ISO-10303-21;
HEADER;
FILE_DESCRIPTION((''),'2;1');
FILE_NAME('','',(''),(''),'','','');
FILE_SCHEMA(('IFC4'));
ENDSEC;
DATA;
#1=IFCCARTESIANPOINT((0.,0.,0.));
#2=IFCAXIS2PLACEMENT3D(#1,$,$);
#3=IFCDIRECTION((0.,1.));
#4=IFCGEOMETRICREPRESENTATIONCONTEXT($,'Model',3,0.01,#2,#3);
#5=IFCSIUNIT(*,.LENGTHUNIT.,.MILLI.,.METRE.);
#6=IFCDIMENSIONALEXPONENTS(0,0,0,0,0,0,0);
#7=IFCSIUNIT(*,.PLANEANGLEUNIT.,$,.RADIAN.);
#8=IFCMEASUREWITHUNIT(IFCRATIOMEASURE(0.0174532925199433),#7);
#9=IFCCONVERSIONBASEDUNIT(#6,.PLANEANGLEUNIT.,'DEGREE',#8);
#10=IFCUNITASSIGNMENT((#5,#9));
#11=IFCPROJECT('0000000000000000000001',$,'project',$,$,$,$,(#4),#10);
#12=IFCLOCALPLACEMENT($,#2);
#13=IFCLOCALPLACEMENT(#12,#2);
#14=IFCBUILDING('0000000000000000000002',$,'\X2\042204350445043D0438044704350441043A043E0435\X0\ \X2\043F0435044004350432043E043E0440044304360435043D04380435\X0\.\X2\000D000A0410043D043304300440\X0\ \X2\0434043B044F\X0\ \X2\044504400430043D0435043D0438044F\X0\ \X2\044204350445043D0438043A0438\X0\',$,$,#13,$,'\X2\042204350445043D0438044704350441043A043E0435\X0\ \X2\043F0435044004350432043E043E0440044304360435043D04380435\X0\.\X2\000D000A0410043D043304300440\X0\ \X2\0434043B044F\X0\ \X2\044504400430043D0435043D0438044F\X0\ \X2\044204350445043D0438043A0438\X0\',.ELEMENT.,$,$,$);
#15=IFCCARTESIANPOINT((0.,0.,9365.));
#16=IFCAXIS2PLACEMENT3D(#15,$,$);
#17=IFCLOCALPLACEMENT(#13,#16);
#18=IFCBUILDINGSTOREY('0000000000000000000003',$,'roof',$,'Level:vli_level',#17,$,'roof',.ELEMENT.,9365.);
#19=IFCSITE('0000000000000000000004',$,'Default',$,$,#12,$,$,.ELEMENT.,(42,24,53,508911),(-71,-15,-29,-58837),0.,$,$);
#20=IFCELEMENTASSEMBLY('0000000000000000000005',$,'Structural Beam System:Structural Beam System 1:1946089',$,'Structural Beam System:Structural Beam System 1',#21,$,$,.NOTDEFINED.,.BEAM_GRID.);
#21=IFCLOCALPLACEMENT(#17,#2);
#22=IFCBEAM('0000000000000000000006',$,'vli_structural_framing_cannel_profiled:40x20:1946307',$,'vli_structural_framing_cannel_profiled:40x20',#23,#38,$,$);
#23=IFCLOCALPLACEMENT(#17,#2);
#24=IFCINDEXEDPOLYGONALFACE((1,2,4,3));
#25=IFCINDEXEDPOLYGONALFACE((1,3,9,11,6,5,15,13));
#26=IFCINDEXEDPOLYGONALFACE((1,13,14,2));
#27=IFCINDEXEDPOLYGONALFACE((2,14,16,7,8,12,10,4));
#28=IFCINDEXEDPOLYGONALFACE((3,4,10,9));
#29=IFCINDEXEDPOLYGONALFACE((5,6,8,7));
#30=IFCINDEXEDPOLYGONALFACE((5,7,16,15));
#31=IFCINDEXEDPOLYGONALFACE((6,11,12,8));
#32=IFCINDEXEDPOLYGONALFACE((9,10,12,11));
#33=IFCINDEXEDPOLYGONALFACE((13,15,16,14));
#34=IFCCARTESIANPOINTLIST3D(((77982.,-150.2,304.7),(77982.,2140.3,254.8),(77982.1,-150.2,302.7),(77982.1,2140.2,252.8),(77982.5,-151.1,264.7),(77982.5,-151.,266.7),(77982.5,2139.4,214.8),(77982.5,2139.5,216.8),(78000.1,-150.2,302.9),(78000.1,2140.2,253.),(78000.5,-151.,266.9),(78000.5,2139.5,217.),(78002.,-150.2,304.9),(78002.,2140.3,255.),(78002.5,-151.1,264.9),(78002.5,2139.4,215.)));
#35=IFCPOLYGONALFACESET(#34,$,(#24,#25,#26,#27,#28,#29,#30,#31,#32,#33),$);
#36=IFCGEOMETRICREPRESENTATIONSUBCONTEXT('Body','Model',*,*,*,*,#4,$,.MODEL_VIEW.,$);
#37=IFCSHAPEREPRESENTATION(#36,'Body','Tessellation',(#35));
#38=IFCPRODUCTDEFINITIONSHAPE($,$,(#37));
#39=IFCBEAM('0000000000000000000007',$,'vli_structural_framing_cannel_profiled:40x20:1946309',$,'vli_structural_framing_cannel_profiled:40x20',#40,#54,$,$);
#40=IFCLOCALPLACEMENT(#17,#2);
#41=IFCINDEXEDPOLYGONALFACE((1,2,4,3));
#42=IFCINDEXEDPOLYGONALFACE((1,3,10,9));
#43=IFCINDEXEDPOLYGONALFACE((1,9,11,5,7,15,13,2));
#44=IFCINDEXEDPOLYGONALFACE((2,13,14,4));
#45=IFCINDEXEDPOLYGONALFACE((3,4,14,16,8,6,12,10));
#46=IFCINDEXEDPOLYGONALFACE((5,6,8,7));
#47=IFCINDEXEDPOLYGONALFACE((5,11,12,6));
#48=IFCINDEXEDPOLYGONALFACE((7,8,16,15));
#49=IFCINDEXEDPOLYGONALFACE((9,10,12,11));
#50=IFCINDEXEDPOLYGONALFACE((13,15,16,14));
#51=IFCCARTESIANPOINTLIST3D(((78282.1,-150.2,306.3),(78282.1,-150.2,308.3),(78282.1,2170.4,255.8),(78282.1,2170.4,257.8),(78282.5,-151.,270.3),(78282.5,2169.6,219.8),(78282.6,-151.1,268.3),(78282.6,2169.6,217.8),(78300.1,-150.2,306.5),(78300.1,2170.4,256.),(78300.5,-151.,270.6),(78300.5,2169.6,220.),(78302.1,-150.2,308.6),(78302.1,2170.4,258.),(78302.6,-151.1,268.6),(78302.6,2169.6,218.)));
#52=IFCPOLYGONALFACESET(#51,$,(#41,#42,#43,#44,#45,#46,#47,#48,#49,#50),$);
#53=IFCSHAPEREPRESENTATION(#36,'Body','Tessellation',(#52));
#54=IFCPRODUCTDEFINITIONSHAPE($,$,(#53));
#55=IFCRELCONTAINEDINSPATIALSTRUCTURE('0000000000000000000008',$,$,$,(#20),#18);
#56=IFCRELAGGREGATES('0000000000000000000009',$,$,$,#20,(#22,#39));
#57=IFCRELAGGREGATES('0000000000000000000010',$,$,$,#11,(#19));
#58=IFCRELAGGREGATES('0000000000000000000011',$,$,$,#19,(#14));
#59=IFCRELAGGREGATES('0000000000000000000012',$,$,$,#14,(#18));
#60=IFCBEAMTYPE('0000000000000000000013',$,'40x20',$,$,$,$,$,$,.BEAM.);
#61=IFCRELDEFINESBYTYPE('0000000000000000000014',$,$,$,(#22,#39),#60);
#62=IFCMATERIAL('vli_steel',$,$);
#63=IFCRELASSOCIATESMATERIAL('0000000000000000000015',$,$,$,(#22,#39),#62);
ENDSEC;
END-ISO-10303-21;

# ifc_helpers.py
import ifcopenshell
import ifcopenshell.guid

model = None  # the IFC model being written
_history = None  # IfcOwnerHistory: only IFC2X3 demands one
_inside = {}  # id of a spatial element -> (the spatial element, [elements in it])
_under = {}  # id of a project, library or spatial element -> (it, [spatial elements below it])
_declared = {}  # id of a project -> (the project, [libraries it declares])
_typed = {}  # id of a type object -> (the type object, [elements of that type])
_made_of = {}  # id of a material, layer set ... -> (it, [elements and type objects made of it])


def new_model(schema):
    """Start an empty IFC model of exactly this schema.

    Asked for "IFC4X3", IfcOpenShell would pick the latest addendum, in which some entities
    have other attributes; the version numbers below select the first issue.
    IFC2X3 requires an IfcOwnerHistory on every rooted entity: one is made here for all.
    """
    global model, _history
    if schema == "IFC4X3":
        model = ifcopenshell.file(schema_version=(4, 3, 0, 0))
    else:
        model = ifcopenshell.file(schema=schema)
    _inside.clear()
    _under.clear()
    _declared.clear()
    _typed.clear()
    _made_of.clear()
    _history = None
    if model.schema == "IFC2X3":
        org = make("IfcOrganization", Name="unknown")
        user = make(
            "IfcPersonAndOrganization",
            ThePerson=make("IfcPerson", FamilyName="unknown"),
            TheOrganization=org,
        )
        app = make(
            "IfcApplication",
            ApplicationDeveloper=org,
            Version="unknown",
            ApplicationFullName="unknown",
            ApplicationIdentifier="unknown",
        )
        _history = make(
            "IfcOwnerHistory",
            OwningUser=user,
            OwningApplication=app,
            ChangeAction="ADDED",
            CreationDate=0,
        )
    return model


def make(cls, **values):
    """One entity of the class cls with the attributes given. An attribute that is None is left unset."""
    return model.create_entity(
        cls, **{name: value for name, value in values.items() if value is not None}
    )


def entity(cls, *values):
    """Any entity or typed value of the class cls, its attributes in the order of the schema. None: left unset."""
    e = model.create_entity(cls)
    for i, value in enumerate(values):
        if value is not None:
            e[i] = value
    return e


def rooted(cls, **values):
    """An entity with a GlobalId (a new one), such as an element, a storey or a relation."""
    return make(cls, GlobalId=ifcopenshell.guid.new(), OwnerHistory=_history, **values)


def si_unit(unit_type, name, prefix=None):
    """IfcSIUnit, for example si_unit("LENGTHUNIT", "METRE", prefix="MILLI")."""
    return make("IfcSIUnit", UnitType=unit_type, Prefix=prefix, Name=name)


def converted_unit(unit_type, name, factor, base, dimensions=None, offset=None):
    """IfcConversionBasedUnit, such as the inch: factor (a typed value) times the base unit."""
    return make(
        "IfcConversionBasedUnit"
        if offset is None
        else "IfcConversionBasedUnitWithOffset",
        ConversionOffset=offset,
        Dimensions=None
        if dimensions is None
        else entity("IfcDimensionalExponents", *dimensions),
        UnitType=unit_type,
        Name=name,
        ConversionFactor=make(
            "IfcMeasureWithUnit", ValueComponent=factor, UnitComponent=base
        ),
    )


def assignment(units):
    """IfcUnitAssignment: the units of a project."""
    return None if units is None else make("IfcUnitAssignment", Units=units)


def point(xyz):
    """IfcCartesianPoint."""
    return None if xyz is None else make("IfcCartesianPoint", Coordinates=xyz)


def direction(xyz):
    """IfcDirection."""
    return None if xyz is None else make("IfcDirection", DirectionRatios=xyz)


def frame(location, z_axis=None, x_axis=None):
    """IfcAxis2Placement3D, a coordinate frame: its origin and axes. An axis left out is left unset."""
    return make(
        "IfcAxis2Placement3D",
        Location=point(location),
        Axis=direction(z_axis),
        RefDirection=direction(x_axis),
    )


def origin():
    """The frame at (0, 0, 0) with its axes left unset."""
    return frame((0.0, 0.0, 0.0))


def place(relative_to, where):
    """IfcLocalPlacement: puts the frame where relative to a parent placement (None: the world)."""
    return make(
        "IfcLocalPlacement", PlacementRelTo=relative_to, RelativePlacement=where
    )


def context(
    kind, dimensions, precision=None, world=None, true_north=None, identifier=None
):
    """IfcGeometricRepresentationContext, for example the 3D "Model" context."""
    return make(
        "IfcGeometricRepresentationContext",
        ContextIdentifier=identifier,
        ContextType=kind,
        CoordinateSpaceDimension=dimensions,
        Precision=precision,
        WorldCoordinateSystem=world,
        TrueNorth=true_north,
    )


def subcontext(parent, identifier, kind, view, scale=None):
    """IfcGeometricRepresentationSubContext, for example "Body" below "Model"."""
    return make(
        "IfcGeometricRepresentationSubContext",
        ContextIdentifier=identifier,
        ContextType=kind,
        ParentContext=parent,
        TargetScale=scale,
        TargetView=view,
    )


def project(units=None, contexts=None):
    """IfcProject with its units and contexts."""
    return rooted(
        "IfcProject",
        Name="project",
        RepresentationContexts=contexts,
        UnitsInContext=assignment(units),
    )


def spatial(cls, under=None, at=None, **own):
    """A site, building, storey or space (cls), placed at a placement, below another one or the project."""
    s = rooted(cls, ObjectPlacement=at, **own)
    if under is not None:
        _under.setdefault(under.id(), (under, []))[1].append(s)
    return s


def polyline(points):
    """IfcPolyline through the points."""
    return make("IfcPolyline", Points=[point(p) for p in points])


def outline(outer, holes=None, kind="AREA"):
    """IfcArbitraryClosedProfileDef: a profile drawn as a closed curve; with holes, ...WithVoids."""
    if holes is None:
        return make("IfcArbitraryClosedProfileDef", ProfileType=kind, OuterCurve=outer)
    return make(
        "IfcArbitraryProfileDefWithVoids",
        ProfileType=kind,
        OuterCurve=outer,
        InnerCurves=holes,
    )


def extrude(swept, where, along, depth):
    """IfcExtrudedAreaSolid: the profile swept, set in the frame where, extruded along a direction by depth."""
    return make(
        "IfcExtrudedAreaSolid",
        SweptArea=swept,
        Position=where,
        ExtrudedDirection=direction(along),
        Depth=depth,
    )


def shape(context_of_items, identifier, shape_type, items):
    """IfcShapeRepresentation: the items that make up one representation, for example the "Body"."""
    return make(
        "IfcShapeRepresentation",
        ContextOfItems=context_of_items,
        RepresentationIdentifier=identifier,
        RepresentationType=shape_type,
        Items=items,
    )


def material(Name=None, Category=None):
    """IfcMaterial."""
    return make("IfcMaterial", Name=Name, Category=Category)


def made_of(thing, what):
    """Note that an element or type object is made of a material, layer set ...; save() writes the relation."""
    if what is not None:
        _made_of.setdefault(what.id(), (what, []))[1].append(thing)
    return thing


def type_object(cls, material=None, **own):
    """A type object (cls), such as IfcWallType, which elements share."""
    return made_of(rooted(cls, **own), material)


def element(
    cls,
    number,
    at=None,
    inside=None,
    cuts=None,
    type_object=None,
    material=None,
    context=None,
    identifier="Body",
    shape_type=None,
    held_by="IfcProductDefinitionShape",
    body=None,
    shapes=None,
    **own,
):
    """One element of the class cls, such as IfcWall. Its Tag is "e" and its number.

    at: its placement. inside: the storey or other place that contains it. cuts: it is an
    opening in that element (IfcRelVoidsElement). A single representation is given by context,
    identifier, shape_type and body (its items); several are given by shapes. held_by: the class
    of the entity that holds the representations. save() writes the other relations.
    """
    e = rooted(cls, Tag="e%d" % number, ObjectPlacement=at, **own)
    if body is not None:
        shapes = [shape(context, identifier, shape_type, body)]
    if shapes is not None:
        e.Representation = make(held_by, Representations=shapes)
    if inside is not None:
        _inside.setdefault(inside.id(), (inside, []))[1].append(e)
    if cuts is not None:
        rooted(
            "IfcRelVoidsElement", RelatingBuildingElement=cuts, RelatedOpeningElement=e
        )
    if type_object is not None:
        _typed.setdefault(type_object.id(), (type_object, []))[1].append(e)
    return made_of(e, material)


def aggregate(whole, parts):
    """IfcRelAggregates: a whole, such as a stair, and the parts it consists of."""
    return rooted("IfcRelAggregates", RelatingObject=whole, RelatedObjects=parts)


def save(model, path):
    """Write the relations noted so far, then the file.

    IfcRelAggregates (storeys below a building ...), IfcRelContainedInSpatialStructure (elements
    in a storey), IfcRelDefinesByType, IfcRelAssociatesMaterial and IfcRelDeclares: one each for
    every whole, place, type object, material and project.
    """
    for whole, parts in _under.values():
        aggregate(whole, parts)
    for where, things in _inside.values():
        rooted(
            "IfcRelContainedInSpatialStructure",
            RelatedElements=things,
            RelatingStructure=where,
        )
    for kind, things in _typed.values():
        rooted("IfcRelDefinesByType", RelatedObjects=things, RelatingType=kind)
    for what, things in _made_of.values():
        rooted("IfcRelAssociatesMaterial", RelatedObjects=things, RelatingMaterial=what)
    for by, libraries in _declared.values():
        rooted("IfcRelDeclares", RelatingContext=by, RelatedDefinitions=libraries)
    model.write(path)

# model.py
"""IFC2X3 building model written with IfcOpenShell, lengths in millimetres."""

from ifc_helpers import new_model, entity, si_unit, converted_unit, direction, frame, origin, place, context, subcontext, project, spatial, polyline, outline, extrude, material, type_object, element, aggregate, save


model = new_model("IFC2X3")

# Units and contexts
model_context = context("Model", 3, precision=0.01, world=origin(), true_north=direction((0.0, 1.0)))
body_context = subcontext(model_context, "Body", "Model", "MODEL_VIEW")
ifc_project = project(units=[si_unit("LENGTHUNIT", "METRE", prefix="MILLI"), converted_unit("PLANEANGLEUNIT", "DEGREE", entity("IfcRatioMeasure", 0.0174532925199433), si_unit("PLANEANGLEUNIT", "RADIAN"), dimensions=[0, 0, 0, 0, 0, 0, 0])], contexts=[model_context])

# Site, building, storey
site_placement = place(None, origin())
site = spatial("IfcSite", under=ifc_project, at=site_placement, Name="Default", CompositionType="ELEMENT", RefLatitude=(42, 24, 53, 508911), RefLongitude=(-71, -15, -29, -58837), RefElevation=0.0)
building_placement = place(site_placement, origin())
building = spatial("IfcBuilding", under=site, at=building_placement, Name="Техническое перевооружение.\r\nАнгар для хранения техники", LongName="Техническое перевооружение.\r\nАнгар для хранения техники", CompositionType="ELEMENT")
storey_placement = place(building_placement, frame((0.0, 0.0, 9365.0)))
storey = spatial("IfcBuildingStorey", under=building, at=storey_placement, Name="roof", ObjectType="Level:vli_level", LongName="roof", CompositionType="ELEMENT", Elevation=9365.0)

# Element assembly, beams
ifc_material = material(Name="vli_steel")
beam_type = type_object("IfcBeamType", Name="40x20", PredefinedType="BEAM")
assembly_1_placement = place(storey_placement, origin())
assembly_1 = element("IfcElementAssembly", 1, at=assembly_1_placement, inside=storey, Name="Structural Beam System:Structural Beam System 1:1946089", ObjectType="Structural Beam System:Structural Beam System 1", AssemblyPlace="NOTDEFINED", PredefinedType="BEAM_GRID")
beam_1_placement = place(assembly_1_placement, frame((78001.4, 2140.3, 255.0), z_axis=(0.0, 0.021775, 0.999763), x_axis=(0.0, -0.999763, 0.021775)))
beam_1 = element("IfcBeam", 2, at=beam_1_placement, type_object=beam_type, material=ifc_material, Name="vli_structural_framing_cannel_profiled:40x20:1946307", ObjectType="vli_structural_framing_cannel_profiled:40x20", context=body_context, shape_type="SweptSolid", body=[
    extrude(outline(polyline([(-10.5, -20.0), (9.5, -20.0), (9.5, -18.0), (-8.5, -18.0), (-8.5, 18.0), (9.5, 18.0), (9.5, 20.0), (-10.5, 20.0), (-10.5, -20.0)])), frame((0.0, -9.7, -20.1), z_axis=(1.0, 0.0, 0.0), x_axis=(0.0, -0.999925, -0.01227)), (0.0, 0.0, 1.0), 2291.0),
])
beam_2_placement = place(assembly_1_placement, frame((78301.5, 2170.4, 258.0), z_axis=(0.0, 0.021775, 0.999763), x_axis=(0.0, -0.999763, 0.021775)))
beam_2 = element("IfcBeam", 3, at=beam_2_placement, type_object=beam_type, material=ifc_material, Name="vli_structural_framing_cannel_profiled:40x20:1946309", ObjectType="vli_structural_framing_cannel_profiled:40x20", context=body_context, shape_type="SweptSolid", body=[
    extrude(outline(polyline([(-10.5, -20.0), (9.5, -20.0), (9.5, -18.0), (-8.5, -18.0), (-8.5, 18.0), (9.5, 18.0), (9.5, 20.0), (-10.5, 20.0), (-10.5, -20.0)])), frame((0.0, -9.7, -20.1), z_axis=(1.0, 0.0, 0.0), x_axis=(0.0, -0.999925, -0.01227)), (0.0, 0.0, 1.0), 2321.2),
])
aggregate(assembly_1, [beam_1, beam_2])

save(model, "model.ifc")
